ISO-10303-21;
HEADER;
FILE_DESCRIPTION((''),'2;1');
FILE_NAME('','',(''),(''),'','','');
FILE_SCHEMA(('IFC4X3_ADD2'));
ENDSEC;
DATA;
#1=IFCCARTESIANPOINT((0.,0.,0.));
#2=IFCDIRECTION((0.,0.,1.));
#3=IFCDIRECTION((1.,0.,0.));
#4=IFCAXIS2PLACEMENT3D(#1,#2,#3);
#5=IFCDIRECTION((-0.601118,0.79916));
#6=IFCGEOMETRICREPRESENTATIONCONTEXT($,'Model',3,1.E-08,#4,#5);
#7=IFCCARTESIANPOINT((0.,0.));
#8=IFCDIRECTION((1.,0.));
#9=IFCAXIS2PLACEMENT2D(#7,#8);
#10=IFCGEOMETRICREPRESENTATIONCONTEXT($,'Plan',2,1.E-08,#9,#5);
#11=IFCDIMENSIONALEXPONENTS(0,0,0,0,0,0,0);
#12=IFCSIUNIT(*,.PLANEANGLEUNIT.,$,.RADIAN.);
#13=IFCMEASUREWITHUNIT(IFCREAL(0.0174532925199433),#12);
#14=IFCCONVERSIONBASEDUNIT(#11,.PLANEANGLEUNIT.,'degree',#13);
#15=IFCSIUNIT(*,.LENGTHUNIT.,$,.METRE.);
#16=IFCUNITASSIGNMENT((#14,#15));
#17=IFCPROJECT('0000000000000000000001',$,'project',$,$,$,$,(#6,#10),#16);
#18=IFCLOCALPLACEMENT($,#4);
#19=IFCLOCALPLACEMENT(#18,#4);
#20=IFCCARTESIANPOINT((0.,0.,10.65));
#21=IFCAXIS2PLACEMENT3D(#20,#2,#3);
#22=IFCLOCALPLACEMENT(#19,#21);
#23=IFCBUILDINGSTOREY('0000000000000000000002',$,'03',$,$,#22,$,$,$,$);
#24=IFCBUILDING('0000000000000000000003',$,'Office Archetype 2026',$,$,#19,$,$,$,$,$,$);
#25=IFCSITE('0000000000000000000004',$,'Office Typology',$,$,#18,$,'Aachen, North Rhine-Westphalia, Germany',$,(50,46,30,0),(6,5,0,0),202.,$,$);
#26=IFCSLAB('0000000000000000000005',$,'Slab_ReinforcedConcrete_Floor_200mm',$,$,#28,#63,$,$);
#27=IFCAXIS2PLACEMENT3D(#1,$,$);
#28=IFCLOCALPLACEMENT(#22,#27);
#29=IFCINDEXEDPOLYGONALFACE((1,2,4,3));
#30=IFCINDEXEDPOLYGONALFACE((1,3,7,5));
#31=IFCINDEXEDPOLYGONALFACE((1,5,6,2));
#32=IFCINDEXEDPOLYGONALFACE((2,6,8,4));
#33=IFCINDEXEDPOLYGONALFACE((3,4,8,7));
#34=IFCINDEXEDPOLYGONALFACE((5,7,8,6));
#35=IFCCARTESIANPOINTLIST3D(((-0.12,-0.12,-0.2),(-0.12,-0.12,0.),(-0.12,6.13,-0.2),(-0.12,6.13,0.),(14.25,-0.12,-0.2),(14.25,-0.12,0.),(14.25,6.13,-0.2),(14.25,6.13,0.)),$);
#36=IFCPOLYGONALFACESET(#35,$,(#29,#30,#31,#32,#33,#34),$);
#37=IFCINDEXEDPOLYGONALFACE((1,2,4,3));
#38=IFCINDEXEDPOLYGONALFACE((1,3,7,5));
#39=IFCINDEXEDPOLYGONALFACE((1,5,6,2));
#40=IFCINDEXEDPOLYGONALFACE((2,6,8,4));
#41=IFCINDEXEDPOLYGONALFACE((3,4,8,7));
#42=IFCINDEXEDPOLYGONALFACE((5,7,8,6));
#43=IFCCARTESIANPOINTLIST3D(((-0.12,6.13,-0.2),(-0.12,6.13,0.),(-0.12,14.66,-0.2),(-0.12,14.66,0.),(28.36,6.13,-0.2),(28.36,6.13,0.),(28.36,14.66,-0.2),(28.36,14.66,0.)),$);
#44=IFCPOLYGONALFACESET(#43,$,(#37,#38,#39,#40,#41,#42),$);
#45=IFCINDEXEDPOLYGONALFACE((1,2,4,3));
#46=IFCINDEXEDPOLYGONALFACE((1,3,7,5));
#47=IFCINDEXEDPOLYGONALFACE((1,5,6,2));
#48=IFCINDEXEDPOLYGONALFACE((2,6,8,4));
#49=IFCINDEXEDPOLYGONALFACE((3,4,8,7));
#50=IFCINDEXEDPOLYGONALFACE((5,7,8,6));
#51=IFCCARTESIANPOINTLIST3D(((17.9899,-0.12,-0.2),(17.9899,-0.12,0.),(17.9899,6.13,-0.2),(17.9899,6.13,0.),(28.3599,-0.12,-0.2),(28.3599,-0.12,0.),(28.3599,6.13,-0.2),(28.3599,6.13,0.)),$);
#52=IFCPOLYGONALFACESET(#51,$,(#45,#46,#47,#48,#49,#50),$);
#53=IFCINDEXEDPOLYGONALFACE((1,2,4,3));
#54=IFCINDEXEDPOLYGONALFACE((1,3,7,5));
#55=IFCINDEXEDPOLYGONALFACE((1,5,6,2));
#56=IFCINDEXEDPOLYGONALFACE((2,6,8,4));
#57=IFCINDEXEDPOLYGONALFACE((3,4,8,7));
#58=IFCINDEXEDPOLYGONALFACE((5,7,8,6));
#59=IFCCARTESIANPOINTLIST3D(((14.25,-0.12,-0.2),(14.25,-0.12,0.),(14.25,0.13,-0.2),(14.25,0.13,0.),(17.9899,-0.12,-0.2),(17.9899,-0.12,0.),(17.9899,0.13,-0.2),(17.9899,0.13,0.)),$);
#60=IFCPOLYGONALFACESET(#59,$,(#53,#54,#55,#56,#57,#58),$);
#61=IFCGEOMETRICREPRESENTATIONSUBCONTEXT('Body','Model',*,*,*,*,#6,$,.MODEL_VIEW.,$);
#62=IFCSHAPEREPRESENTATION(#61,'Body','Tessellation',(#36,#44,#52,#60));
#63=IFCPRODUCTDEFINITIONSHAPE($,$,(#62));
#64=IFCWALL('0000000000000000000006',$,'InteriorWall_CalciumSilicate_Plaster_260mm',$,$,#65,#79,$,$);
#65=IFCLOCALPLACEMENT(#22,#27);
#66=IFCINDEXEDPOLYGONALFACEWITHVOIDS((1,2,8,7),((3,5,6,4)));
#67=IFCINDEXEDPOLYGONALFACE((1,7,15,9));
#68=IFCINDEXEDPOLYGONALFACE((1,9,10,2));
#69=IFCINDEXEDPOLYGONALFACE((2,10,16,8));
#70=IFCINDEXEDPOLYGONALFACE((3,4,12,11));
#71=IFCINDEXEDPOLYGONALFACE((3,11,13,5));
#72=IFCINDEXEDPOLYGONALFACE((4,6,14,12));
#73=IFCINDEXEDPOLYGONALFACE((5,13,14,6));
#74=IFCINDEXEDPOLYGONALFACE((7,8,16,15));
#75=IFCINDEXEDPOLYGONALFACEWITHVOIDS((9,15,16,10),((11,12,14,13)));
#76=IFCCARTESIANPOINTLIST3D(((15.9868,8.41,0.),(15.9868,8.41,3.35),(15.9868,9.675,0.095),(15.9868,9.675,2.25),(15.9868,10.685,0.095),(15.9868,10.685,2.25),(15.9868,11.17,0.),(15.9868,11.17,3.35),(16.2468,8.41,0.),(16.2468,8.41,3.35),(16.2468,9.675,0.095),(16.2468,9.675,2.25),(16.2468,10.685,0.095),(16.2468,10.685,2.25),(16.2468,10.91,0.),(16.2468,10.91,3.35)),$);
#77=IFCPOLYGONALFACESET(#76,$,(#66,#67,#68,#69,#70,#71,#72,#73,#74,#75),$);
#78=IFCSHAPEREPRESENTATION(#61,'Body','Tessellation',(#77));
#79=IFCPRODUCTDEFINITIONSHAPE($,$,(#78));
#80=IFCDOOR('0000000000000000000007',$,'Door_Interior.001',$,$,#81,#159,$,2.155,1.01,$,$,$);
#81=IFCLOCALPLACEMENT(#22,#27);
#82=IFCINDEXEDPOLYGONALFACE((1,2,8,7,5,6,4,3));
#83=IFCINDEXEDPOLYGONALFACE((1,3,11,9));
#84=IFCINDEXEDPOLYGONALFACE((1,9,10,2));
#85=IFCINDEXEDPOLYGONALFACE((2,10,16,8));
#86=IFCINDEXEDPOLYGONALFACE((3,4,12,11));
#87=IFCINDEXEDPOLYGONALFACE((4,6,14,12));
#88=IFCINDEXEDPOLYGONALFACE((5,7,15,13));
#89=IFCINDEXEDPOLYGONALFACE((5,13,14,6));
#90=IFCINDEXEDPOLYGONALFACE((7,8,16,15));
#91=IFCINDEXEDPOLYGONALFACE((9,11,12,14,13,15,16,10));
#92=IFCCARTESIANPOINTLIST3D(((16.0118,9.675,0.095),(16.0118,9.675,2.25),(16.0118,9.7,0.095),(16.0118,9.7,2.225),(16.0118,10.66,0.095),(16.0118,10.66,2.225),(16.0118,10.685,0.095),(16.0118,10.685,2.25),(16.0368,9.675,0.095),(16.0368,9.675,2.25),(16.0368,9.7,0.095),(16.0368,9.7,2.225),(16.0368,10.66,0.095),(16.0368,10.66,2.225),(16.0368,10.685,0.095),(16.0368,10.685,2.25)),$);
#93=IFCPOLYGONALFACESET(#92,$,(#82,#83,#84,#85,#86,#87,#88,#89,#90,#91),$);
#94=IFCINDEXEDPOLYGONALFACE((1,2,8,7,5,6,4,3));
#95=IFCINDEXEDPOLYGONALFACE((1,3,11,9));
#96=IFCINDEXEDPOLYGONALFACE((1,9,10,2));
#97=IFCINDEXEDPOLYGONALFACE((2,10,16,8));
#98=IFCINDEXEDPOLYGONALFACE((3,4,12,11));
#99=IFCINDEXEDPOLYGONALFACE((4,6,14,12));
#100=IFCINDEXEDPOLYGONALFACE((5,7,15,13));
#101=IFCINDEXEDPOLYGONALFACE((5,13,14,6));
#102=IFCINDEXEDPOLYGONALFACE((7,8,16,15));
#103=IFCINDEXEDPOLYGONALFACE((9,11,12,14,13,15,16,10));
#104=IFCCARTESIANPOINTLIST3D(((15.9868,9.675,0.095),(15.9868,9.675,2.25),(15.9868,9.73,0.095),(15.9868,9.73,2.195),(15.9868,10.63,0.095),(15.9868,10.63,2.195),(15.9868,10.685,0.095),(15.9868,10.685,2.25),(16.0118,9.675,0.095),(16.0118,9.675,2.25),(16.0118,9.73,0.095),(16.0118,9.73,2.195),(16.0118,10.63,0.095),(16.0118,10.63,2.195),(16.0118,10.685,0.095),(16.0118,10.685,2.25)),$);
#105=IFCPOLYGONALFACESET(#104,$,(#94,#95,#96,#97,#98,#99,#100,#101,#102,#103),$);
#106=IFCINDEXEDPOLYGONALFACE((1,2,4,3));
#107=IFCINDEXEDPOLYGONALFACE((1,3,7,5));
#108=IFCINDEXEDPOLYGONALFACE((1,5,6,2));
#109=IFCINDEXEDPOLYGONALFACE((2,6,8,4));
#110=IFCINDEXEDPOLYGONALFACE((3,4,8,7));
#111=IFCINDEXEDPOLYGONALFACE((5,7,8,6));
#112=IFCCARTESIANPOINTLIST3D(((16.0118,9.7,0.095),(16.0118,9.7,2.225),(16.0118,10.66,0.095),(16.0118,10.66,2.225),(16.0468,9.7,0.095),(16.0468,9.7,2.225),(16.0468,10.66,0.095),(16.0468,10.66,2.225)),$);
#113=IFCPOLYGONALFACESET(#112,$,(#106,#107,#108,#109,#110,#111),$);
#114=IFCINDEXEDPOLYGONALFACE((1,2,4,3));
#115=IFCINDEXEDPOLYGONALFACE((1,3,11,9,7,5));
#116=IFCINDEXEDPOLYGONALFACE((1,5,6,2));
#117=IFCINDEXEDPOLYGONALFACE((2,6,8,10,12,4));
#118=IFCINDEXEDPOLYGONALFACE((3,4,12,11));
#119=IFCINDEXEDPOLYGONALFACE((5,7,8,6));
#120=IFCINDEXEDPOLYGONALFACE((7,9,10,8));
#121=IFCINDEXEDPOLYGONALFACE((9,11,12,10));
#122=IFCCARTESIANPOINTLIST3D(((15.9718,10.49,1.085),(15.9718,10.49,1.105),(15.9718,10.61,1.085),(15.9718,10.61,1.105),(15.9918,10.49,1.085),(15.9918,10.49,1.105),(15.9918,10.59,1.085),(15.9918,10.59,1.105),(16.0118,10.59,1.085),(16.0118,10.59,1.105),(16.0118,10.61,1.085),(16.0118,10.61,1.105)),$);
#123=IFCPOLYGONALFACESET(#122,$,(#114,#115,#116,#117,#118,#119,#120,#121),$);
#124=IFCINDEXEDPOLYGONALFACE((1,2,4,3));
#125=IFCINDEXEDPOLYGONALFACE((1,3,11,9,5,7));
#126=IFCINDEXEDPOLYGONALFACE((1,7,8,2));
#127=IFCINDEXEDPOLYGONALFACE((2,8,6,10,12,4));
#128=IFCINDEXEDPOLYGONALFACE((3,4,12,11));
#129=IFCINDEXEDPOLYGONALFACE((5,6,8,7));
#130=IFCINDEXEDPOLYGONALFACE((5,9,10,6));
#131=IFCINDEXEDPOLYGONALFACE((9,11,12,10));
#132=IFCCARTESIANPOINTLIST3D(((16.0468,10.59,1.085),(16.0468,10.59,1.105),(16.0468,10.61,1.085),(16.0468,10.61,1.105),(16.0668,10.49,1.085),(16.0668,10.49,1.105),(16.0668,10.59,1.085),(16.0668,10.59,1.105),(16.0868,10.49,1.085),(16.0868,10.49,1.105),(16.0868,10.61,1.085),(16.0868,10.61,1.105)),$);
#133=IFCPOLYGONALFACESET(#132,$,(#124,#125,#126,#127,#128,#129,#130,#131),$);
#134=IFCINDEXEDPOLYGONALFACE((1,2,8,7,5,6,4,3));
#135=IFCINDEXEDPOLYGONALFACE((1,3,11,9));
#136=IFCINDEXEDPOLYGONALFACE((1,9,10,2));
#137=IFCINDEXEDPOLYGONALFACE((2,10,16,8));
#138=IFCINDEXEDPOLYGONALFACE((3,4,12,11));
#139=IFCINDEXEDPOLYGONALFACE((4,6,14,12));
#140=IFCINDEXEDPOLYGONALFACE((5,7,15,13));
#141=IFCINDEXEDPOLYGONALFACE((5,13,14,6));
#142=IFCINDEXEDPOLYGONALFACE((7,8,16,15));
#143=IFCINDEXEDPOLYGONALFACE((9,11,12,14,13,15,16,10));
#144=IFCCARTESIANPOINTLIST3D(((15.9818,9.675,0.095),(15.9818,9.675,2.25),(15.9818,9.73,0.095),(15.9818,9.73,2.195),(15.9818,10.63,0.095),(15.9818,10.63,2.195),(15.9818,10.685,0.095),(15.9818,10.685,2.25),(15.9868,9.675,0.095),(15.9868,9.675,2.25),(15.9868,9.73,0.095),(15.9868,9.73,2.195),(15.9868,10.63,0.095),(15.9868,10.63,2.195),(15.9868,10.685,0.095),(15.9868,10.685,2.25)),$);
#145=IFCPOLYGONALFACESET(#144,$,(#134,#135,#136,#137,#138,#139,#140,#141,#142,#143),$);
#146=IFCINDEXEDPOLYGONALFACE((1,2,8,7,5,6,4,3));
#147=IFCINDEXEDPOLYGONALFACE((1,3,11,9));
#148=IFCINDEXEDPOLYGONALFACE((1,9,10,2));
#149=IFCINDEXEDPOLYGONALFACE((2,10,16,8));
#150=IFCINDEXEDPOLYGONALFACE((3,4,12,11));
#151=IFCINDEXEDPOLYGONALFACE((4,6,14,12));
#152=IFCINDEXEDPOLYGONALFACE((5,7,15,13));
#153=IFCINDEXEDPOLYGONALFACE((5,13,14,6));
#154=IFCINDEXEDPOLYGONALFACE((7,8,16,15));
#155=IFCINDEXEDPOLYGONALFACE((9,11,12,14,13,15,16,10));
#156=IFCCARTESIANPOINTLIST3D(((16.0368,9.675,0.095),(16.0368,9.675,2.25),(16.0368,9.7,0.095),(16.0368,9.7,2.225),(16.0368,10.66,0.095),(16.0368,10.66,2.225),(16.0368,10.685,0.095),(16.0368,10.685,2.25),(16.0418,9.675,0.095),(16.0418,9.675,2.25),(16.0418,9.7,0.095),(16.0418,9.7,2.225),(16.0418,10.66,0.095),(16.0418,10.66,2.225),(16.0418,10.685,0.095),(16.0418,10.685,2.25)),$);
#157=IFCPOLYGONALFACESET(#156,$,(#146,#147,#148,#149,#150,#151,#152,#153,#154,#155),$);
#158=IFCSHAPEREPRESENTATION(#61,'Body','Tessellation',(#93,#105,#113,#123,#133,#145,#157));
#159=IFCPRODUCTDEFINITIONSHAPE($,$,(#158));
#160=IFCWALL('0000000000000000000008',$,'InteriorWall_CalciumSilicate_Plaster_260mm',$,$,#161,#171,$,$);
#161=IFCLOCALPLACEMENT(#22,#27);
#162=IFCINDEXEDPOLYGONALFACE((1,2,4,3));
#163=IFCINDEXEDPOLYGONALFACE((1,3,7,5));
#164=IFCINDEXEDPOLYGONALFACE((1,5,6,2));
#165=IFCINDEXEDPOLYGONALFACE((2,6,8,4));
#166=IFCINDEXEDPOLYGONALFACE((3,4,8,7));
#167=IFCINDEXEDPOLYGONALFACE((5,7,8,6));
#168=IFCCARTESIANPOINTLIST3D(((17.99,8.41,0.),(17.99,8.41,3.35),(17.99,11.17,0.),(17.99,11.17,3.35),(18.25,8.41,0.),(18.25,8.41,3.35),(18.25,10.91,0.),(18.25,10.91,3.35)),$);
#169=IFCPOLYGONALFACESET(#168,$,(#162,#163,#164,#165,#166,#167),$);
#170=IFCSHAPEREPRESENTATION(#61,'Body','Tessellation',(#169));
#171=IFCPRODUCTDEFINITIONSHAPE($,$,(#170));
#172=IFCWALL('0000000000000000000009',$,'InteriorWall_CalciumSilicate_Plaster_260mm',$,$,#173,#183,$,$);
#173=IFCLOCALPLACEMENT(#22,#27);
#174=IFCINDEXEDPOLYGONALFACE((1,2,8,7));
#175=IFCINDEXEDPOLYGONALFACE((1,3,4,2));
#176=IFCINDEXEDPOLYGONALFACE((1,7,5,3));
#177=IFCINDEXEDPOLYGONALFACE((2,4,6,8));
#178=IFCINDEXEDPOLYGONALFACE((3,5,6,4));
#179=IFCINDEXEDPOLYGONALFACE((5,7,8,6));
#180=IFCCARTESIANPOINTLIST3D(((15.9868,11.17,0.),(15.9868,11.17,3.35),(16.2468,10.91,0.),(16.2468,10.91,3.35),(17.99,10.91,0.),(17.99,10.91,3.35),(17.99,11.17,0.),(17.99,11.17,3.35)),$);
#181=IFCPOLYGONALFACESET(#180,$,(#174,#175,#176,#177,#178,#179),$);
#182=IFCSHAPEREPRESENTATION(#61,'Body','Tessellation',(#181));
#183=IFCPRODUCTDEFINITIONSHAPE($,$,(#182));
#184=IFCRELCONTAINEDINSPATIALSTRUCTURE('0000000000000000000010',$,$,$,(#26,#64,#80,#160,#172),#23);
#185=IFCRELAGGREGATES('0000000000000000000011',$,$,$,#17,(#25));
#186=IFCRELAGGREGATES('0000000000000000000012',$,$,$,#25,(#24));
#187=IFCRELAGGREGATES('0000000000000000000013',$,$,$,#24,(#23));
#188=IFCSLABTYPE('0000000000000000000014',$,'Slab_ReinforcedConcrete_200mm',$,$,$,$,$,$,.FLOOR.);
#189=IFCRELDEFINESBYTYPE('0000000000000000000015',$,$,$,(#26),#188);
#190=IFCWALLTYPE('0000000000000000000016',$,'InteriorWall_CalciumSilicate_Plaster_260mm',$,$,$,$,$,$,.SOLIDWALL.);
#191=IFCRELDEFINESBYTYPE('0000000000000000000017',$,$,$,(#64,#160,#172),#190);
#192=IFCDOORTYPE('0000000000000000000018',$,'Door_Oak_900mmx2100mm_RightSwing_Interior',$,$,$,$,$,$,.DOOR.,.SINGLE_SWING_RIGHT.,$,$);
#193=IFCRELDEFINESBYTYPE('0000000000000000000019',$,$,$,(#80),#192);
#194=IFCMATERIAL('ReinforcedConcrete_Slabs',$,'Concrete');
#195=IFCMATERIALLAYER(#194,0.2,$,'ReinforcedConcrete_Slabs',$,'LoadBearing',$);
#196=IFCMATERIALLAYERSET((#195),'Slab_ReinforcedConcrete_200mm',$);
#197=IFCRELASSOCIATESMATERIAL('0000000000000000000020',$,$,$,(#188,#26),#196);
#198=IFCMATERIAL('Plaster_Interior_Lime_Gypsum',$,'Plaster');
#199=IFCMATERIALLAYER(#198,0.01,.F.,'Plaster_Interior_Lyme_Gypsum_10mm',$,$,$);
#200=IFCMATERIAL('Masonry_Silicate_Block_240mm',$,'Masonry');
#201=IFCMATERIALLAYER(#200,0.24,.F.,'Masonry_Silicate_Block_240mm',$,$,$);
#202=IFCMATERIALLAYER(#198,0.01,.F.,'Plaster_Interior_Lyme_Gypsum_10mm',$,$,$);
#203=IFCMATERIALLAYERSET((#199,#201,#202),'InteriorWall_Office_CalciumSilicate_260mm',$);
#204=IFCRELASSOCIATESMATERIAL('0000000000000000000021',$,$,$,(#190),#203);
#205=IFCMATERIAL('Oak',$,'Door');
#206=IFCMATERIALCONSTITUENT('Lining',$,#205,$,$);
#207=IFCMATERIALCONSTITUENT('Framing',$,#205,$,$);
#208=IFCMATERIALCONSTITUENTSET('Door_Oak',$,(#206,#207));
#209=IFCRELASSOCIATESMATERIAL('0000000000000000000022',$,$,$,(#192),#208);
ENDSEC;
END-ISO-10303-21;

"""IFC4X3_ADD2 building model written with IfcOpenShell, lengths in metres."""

from ifc_helpers import new_model, entity, si_unit, converted_unit, direction, frame, origin_with_axes, origin_2d_with_axis, place, context, subcontext, project, spatial, line, indexed_curve, outline, extrude, source, transform, mapped, material, layer, layer_set, layer_usage, constituent, constituent_set, type_object, type_shapes, element, fill, save


model = new_model("IFC4X3_ADD2")

# Units and contexts
model_context = context("Model", 3, precision=1e-08, world=origin_with_axes(), true_north=direction((-0.601118, 0.79916)))
plan_context = context("Plan", 2, precision=1e-08, world=origin_2d_with_axis(), true_north=direction((-0.601118, 0.79916)))
body_context = subcontext(model_context, "Body", "Model", "MODEL_VIEW")
ifc_project = project(units=[converted_unit("PLANEANGLEUNIT", "degree", entity("IfcReal", 0.0174532925199433), si_unit("PLANEANGLEUNIT", "RADIAN"), dimensions=[0, 0, 0, 0, 0, 0, 0]), si_unit("LENGTHUNIT", "METRE")], contexts=[model_context, plan_context])

# Site, building, storey
site_placement = place(None, origin_with_axes())
site = spatial("IfcSite", under=ifc_project, at=site_placement, Name="Office Typology", LongName="Aachen, North Rhine-Westphalia, Germany", RefLatitude=(50, 46, 30, 0), RefLongitude=(6, 5, 0, 0), RefElevation=202.0)
building_placement = place(site_placement, origin_with_axes())
building = spatial("IfcBuilding", under=site, at=building_placement, Name="Office Archetype 2026")
storey_placement = place(building_placement, frame((0.0, 0.0, 10.65), z_axis=(0.0, 0.0, 1.0), x_axis=(1.0, 0.0, 0.0)))
storey = spatial("IfcBuildingStorey", under=building, at=storey_placement, Name="03")

# Slab
ifc_material_1 = material(Name="ReinforcedConcrete_Slabs", Category="Concrete")
ifc_layer_1 = layer(ifc_material_1, 0.2, Name="ReinforcedConcrete_Slabs", Category="LoadBearing")
ifc_layer_set_1 = layer_set([ifc_layer_1], Name="Slab_ReinforcedConcrete_200mm")
slab_type = type_object("IfcSlabType", Name="Slab_ReinforcedConcrete_200mm", PredefinedType="FLOOR", material=ifc_layer_set_1)
ifc_layer_usage_1 = layer_usage(ifc_layer_set_1, "AXIS3", "POSITIVE", 0.0)
slab_1_placement = place(storey_placement, frame((17.9899, 6.13, 0.0), z_axis=(0.0, 0.0, 1.0), x_axis=(1.0, 0.0, 0.0)))
element("IfcSlab", 1, at=slab_1_placement, inside=storey, type_object=slab_type, material=ifc_layer_usage_1, Name="Slab_ReinforcedConcrete_Floor_200mm", context=body_context, shape_type="SweptSolid", body=[
    extrude(outline(indexed_curve([(0.0, -6.25), (14.37, -6.25), (14.37, 0.0), (0.0, 0.0), (0.0, -6.25)])), frame((-18.1099, 0.0, -0.2), z_axis=(0.0, 0.0, 1.0), x_axis=(1.0, 0.0, 0.0)), (0.0, 0.0, 1.0), 0.2),
    extrude(outline(indexed_curve([(0.0, 0.0), (28.48, 0.0), (28.48, -8.53), (0.0, -8.53), (0.0, 0.0)])), frame((-18.1099, 8.53, -0.2), z_axis=(0.0, 0.0, 1.0), x_axis=(1.0, 0.0, 0.0)), (0.0, 0.0, 1.0), 0.2),
    extrude(outline(indexed_curve([(0.0, 0.0), (0.0, -6.25), (10.37, -6.25), (10.37, 0.0), (0.0, 0.0)])), frame((0.0, 0.0, -0.2), z_axis=(0.0, 0.0, 1.0), x_axis=(1.0, 0.0, 0.0)), (0.0, 0.0, 1.0), 0.2),
    extrude(outline(indexed_curve([(0.0, 0.0), (3.7399, 0.0), (3.7399, 0.25), (0.0, 0.25), (0.0, 0.0)])), frame((-3.7399, -6.25, -0.2), z_axis=(0.0, 0.0, 1.0), x_axis=(1.0, 0.0, 0.0)), (0.0, 0.0, 1.0), 0.2),
])

# Wall, opening, door
ifc_material_2 = material(Name="Plaster_Interior_Lime_Gypsum", Category="Plaster")
ifc_layer_2 = layer(ifc_material_2, 0.01, ventilated=False, Name="Plaster_Interior_Lyme_Gypsum_10mm")
ifc_material_3 = material(Name="Masonry_Silicate_Block_240mm", Category="Masonry")
ifc_layer_3 = layer(ifc_material_3, 0.24, ventilated=False, Name="Masonry_Silicate_Block_240mm")
ifc_layer_4 = layer(ifc_material_2, 0.01, ventilated=False, Name="Plaster_Interior_Lyme_Gypsum_10mm")
ifc_layer_set_2 = layer_set([ifc_layer_2, ifc_layer_3, ifc_layer_4], Name="InteriorWall_Office_CalciumSilicate_260mm")
wall_type_1 = type_object("IfcWallType", Name="InteriorWall_CalciumSilicate_Plaster_260mm", PredefinedType="SOLIDWALL", material=ifc_layer_set_2)
wall_1_placement = place(storey_placement, frame((15.9868, 11.17, 0.0), z_axis=(0.0, 0.0, 1.0), x_axis=(0.0, -1.0, 0.0)))
wall_1 = element("IfcWall", 2, at=wall_1_placement, inside=storey, type_object=wall_type_1, Name="InteriorWall_CalciumSilicate_Plaster_260mm", context=body_context, shape_type="SweptSolid", body=[
    extrude(outline(indexed_curve([(0.0, 0.0), (0.26, 0.26), (2.76, 0.26), (2.76, 0.0)], segments=[line(1, 2, 3, 4, 1)])), origin_with_axes(), (0.0, 0.0, 1.0), 3.35),
])
shared_shape_1 = source(origin_with_axes(), body_context, "Body", "SweptSolid", [
    extrude(outline(indexed_curve([(0.0, 2.155), (1.01, 2.155), (1.01, 0.0), (0.0, 0.0), (0.0, 2.155)])), frame((0.0, 0.0, 0.0), z_axis=(0.0, -1.0, 0.0), x_axis=(1.0, 0.0, 0.0)), (0.0, 0.0, -1.0), 0.26),
])
opening_1_placement = place(wall_1_placement, frame((0.485, 0.0, 0.095), z_axis=(0.0, 0.0, 1.0), x_axis=(1.0, 0.0, 0.0)))
opening_1 = element("IfcOpeningElement", 3, at=opening_1_placement, cuts=wall_1, PredefinedType="OPENING", context=body_context, shape_type="MappedRepresentation", body=[
    mapped(shared_shape_1, transform((0.0, 0.0, 0.0), x_axis=(1.0, 0.0, 0.0), y_axis=(0.0, 1.0, 0.0), z_axis=(0.0, 0.0, 1.0), scale=1.0)),
])
ifc_material_4 = material(Name="Oak", Category="Door")
ifc_constituent_1 = constituent(ifc_material_4, Name="Lining")
ifc_constituent_2 = constituent(ifc_material_4, Name="Framing")
ifc_constituent_set_1 = constituent_set(constituents=[ifc_constituent_1, ifc_constituent_2], Name="Door_Oak")
door_type_1 = type_object("IfcDoorType", Name="Door_Oak_900mmx2100mm_RightSwing_Interior", OperationType="SINGLE_SWING_RIGHT", PredefinedType="DOOR", material=ifc_constituent_set_1)
shared_shape_2 = source(origin_with_axes(), body_context, "Body", "SweptSolid", [
    extrude(outline(indexed_curve([(0.0, 0.0), (0.0, 2.155), (1.01, 2.155), (1.01, 0.0), (0.985, 0.0), (0.985, 2.13), (0.025, 2.13), (0.025, 0.0)], segments=[line(1, 2, 3, 4, 5, 6, 7, 8, 1)])), frame((0.0, 0.025, 0.0), z_axis=(0.0, -1.0, 0.0), x_axis=(1.0, 0.0, 0.0)), (0.0, 0.0, -1.0), 0.025),
    extrude(outline(indexed_curve([(0.0, 0.0), (0.0, 2.155), (1.01, 2.155), (1.01, 0.0), (0.955, 0.0), (0.955, 2.1), (0.055, 2.1), (0.055, 0.0)], segments=[line(1, 2, 3, 4, 5, 6, 7, 8, 1)])), frame((0.0, 0.0, 0.0), z_axis=(0.0, -1.0, 0.0), x_axis=(1.0, 0.0, 0.0)), (0.0, 0.0, -1.0), 0.025),
    extrude(outline(indexed_curve([(0.0, 0.0), (0.96, 0.0), (0.96, 0.035), (0.0, 0.035)], segments=[line(1, 2, 3, 4, 1)])), frame((0.025, 0.025, 0.0), z_axis=(0.0, 0.0, 1.0), x_axis=(1.0, 0.0, 0.0)), (0.0, 0.0, 1.0), 2.13),
    extrude(outline(indexed_curve([(0.0, 0.0), (0.0, -0.04), (0.12, -0.04), (0.12, -0.02), (0.02, -0.02), (0.02, 0.0)], segments=[line(1, 2, 3, 4, 5, 6, 1)])), frame((0.075, 0.025, 0.99), z_axis=(0.0, 0.0, 1.0), x_axis=(1.0, 0.0, 0.0)), (0.0, 0.0, 1.0), 0.02),
    extrude(outline(indexed_curve([(0.0, 0.0), (0.0, 0.04), (0.12, 0.04), (0.12, 0.02), (0.02, 0.02), (0.02, 0.0)], segments=[line(1, 2, 3, 4, 5, 6, 1)])), frame((0.075, 0.06, 0.99), z_axis=(0.0, 0.0, 1.0), x_axis=(1.0, 0.0, 0.0)), (0.0, 0.0, 1.0), 0.02),
    extrude(outline(indexed_curve([(0.0, 0.0), (0.0, 2.155), (1.01, 2.155), (1.01, 0.0), (0.955, 0.0), (0.955, 2.1), (0.055, 2.1), (0.055, 0.0)], segments=[line(1, 2, 3, 4, 5, 6, 7, 8, 1)])), frame((0.0, -0.005, 0.0), z_axis=(0.0, -1.0, 0.0), x_axis=(1.0, 0.0, 0.0)), (0.0, 0.0, -1.0), 0.005),
    extrude(outline(indexed_curve([(0.0, 0.0), (0.0, 2.155), (1.01, 2.155), (1.01, 0.0), (0.985, 0.0), (0.985, 2.13), (0.025, 2.13), (0.025, 0.0)], segments=[line(1, 2, 3, 4, 5, 6, 7, 8, 1)])), frame((0.0, 0.05, 0.0), z_axis=(0.0, -1.0, 0.0), x_axis=(1.0, 0.0, 0.0)), (0.0, 0.0, -1.0), 0.005),
])
type_shapes(door_type_1, [shared_shape_2])
door_1_placement = place(opening_1_placement, origin_with_axes())
door_1 = element("IfcDoor", 4, at=door_1_placement, inside=storey, type_object=door_type_1, Name="Door_Interior.001", OverallHeight=2.155, OverallWidth=1.01, context=body_context, shape_type="MappedRepresentation", body=[
    mapped(shared_shape_2, transform((0.0, 0.0, 0.0), x_axis=(1.0, 0.0, 0.0), y_axis=(0.0, 1.0, 0.0), z_axis=(0.0, 0.0, 1.0), scale=1.0)),
])
fill(opening_1, door_1)

# Walls
wall_2_placement = place(storey_placement, frame((17.99, 11.17, 0.0), z_axis=(0.0, 0.0, 1.0), x_axis=(0.0, -1.0, 0.0)))
element("IfcWall", 5, at=wall_2_placement, inside=storey, type_object=wall_type_1, Name="InteriorWall_CalciumSilicate_Plaster_260mm", context=body_context, shape_type="SweptSolid", body=[
    extrude(outline(indexed_curve([(0.0, 0.0), (0.26, 0.26), (2.76, 0.26), (2.76, 0.0)], segments=[line(1, 2, 3, 4, 1)])), origin_with_axes(), (0.0, 0.0, 1.0), 3.35),
])
wall_3_placement = place(storey_placement, frame((17.99, 11.17, 0.0), z_axis=(0.0, 0.0, 1.0), x_axis=(-1.0, 0.0, 0.0)))
element("IfcWall", 6, at=wall_3_placement, inside=storey, type_object=wall_type_1, Name="InteriorWall_CalciumSilicate_Plaster_260mm", context=body_context, shape_type="SweptSolid", body=[
    extrude(outline(indexed_curve([(0.0, 0.0), (0.0, 0.26), (1.7432, 0.26), (2.0032, 0.0)], segments=[line(1, 2, 3, 4, 1)])), origin_with_axes(), (0.0, 0.0, 1.0), 3.35),
])

save(model, "model.ifc")
